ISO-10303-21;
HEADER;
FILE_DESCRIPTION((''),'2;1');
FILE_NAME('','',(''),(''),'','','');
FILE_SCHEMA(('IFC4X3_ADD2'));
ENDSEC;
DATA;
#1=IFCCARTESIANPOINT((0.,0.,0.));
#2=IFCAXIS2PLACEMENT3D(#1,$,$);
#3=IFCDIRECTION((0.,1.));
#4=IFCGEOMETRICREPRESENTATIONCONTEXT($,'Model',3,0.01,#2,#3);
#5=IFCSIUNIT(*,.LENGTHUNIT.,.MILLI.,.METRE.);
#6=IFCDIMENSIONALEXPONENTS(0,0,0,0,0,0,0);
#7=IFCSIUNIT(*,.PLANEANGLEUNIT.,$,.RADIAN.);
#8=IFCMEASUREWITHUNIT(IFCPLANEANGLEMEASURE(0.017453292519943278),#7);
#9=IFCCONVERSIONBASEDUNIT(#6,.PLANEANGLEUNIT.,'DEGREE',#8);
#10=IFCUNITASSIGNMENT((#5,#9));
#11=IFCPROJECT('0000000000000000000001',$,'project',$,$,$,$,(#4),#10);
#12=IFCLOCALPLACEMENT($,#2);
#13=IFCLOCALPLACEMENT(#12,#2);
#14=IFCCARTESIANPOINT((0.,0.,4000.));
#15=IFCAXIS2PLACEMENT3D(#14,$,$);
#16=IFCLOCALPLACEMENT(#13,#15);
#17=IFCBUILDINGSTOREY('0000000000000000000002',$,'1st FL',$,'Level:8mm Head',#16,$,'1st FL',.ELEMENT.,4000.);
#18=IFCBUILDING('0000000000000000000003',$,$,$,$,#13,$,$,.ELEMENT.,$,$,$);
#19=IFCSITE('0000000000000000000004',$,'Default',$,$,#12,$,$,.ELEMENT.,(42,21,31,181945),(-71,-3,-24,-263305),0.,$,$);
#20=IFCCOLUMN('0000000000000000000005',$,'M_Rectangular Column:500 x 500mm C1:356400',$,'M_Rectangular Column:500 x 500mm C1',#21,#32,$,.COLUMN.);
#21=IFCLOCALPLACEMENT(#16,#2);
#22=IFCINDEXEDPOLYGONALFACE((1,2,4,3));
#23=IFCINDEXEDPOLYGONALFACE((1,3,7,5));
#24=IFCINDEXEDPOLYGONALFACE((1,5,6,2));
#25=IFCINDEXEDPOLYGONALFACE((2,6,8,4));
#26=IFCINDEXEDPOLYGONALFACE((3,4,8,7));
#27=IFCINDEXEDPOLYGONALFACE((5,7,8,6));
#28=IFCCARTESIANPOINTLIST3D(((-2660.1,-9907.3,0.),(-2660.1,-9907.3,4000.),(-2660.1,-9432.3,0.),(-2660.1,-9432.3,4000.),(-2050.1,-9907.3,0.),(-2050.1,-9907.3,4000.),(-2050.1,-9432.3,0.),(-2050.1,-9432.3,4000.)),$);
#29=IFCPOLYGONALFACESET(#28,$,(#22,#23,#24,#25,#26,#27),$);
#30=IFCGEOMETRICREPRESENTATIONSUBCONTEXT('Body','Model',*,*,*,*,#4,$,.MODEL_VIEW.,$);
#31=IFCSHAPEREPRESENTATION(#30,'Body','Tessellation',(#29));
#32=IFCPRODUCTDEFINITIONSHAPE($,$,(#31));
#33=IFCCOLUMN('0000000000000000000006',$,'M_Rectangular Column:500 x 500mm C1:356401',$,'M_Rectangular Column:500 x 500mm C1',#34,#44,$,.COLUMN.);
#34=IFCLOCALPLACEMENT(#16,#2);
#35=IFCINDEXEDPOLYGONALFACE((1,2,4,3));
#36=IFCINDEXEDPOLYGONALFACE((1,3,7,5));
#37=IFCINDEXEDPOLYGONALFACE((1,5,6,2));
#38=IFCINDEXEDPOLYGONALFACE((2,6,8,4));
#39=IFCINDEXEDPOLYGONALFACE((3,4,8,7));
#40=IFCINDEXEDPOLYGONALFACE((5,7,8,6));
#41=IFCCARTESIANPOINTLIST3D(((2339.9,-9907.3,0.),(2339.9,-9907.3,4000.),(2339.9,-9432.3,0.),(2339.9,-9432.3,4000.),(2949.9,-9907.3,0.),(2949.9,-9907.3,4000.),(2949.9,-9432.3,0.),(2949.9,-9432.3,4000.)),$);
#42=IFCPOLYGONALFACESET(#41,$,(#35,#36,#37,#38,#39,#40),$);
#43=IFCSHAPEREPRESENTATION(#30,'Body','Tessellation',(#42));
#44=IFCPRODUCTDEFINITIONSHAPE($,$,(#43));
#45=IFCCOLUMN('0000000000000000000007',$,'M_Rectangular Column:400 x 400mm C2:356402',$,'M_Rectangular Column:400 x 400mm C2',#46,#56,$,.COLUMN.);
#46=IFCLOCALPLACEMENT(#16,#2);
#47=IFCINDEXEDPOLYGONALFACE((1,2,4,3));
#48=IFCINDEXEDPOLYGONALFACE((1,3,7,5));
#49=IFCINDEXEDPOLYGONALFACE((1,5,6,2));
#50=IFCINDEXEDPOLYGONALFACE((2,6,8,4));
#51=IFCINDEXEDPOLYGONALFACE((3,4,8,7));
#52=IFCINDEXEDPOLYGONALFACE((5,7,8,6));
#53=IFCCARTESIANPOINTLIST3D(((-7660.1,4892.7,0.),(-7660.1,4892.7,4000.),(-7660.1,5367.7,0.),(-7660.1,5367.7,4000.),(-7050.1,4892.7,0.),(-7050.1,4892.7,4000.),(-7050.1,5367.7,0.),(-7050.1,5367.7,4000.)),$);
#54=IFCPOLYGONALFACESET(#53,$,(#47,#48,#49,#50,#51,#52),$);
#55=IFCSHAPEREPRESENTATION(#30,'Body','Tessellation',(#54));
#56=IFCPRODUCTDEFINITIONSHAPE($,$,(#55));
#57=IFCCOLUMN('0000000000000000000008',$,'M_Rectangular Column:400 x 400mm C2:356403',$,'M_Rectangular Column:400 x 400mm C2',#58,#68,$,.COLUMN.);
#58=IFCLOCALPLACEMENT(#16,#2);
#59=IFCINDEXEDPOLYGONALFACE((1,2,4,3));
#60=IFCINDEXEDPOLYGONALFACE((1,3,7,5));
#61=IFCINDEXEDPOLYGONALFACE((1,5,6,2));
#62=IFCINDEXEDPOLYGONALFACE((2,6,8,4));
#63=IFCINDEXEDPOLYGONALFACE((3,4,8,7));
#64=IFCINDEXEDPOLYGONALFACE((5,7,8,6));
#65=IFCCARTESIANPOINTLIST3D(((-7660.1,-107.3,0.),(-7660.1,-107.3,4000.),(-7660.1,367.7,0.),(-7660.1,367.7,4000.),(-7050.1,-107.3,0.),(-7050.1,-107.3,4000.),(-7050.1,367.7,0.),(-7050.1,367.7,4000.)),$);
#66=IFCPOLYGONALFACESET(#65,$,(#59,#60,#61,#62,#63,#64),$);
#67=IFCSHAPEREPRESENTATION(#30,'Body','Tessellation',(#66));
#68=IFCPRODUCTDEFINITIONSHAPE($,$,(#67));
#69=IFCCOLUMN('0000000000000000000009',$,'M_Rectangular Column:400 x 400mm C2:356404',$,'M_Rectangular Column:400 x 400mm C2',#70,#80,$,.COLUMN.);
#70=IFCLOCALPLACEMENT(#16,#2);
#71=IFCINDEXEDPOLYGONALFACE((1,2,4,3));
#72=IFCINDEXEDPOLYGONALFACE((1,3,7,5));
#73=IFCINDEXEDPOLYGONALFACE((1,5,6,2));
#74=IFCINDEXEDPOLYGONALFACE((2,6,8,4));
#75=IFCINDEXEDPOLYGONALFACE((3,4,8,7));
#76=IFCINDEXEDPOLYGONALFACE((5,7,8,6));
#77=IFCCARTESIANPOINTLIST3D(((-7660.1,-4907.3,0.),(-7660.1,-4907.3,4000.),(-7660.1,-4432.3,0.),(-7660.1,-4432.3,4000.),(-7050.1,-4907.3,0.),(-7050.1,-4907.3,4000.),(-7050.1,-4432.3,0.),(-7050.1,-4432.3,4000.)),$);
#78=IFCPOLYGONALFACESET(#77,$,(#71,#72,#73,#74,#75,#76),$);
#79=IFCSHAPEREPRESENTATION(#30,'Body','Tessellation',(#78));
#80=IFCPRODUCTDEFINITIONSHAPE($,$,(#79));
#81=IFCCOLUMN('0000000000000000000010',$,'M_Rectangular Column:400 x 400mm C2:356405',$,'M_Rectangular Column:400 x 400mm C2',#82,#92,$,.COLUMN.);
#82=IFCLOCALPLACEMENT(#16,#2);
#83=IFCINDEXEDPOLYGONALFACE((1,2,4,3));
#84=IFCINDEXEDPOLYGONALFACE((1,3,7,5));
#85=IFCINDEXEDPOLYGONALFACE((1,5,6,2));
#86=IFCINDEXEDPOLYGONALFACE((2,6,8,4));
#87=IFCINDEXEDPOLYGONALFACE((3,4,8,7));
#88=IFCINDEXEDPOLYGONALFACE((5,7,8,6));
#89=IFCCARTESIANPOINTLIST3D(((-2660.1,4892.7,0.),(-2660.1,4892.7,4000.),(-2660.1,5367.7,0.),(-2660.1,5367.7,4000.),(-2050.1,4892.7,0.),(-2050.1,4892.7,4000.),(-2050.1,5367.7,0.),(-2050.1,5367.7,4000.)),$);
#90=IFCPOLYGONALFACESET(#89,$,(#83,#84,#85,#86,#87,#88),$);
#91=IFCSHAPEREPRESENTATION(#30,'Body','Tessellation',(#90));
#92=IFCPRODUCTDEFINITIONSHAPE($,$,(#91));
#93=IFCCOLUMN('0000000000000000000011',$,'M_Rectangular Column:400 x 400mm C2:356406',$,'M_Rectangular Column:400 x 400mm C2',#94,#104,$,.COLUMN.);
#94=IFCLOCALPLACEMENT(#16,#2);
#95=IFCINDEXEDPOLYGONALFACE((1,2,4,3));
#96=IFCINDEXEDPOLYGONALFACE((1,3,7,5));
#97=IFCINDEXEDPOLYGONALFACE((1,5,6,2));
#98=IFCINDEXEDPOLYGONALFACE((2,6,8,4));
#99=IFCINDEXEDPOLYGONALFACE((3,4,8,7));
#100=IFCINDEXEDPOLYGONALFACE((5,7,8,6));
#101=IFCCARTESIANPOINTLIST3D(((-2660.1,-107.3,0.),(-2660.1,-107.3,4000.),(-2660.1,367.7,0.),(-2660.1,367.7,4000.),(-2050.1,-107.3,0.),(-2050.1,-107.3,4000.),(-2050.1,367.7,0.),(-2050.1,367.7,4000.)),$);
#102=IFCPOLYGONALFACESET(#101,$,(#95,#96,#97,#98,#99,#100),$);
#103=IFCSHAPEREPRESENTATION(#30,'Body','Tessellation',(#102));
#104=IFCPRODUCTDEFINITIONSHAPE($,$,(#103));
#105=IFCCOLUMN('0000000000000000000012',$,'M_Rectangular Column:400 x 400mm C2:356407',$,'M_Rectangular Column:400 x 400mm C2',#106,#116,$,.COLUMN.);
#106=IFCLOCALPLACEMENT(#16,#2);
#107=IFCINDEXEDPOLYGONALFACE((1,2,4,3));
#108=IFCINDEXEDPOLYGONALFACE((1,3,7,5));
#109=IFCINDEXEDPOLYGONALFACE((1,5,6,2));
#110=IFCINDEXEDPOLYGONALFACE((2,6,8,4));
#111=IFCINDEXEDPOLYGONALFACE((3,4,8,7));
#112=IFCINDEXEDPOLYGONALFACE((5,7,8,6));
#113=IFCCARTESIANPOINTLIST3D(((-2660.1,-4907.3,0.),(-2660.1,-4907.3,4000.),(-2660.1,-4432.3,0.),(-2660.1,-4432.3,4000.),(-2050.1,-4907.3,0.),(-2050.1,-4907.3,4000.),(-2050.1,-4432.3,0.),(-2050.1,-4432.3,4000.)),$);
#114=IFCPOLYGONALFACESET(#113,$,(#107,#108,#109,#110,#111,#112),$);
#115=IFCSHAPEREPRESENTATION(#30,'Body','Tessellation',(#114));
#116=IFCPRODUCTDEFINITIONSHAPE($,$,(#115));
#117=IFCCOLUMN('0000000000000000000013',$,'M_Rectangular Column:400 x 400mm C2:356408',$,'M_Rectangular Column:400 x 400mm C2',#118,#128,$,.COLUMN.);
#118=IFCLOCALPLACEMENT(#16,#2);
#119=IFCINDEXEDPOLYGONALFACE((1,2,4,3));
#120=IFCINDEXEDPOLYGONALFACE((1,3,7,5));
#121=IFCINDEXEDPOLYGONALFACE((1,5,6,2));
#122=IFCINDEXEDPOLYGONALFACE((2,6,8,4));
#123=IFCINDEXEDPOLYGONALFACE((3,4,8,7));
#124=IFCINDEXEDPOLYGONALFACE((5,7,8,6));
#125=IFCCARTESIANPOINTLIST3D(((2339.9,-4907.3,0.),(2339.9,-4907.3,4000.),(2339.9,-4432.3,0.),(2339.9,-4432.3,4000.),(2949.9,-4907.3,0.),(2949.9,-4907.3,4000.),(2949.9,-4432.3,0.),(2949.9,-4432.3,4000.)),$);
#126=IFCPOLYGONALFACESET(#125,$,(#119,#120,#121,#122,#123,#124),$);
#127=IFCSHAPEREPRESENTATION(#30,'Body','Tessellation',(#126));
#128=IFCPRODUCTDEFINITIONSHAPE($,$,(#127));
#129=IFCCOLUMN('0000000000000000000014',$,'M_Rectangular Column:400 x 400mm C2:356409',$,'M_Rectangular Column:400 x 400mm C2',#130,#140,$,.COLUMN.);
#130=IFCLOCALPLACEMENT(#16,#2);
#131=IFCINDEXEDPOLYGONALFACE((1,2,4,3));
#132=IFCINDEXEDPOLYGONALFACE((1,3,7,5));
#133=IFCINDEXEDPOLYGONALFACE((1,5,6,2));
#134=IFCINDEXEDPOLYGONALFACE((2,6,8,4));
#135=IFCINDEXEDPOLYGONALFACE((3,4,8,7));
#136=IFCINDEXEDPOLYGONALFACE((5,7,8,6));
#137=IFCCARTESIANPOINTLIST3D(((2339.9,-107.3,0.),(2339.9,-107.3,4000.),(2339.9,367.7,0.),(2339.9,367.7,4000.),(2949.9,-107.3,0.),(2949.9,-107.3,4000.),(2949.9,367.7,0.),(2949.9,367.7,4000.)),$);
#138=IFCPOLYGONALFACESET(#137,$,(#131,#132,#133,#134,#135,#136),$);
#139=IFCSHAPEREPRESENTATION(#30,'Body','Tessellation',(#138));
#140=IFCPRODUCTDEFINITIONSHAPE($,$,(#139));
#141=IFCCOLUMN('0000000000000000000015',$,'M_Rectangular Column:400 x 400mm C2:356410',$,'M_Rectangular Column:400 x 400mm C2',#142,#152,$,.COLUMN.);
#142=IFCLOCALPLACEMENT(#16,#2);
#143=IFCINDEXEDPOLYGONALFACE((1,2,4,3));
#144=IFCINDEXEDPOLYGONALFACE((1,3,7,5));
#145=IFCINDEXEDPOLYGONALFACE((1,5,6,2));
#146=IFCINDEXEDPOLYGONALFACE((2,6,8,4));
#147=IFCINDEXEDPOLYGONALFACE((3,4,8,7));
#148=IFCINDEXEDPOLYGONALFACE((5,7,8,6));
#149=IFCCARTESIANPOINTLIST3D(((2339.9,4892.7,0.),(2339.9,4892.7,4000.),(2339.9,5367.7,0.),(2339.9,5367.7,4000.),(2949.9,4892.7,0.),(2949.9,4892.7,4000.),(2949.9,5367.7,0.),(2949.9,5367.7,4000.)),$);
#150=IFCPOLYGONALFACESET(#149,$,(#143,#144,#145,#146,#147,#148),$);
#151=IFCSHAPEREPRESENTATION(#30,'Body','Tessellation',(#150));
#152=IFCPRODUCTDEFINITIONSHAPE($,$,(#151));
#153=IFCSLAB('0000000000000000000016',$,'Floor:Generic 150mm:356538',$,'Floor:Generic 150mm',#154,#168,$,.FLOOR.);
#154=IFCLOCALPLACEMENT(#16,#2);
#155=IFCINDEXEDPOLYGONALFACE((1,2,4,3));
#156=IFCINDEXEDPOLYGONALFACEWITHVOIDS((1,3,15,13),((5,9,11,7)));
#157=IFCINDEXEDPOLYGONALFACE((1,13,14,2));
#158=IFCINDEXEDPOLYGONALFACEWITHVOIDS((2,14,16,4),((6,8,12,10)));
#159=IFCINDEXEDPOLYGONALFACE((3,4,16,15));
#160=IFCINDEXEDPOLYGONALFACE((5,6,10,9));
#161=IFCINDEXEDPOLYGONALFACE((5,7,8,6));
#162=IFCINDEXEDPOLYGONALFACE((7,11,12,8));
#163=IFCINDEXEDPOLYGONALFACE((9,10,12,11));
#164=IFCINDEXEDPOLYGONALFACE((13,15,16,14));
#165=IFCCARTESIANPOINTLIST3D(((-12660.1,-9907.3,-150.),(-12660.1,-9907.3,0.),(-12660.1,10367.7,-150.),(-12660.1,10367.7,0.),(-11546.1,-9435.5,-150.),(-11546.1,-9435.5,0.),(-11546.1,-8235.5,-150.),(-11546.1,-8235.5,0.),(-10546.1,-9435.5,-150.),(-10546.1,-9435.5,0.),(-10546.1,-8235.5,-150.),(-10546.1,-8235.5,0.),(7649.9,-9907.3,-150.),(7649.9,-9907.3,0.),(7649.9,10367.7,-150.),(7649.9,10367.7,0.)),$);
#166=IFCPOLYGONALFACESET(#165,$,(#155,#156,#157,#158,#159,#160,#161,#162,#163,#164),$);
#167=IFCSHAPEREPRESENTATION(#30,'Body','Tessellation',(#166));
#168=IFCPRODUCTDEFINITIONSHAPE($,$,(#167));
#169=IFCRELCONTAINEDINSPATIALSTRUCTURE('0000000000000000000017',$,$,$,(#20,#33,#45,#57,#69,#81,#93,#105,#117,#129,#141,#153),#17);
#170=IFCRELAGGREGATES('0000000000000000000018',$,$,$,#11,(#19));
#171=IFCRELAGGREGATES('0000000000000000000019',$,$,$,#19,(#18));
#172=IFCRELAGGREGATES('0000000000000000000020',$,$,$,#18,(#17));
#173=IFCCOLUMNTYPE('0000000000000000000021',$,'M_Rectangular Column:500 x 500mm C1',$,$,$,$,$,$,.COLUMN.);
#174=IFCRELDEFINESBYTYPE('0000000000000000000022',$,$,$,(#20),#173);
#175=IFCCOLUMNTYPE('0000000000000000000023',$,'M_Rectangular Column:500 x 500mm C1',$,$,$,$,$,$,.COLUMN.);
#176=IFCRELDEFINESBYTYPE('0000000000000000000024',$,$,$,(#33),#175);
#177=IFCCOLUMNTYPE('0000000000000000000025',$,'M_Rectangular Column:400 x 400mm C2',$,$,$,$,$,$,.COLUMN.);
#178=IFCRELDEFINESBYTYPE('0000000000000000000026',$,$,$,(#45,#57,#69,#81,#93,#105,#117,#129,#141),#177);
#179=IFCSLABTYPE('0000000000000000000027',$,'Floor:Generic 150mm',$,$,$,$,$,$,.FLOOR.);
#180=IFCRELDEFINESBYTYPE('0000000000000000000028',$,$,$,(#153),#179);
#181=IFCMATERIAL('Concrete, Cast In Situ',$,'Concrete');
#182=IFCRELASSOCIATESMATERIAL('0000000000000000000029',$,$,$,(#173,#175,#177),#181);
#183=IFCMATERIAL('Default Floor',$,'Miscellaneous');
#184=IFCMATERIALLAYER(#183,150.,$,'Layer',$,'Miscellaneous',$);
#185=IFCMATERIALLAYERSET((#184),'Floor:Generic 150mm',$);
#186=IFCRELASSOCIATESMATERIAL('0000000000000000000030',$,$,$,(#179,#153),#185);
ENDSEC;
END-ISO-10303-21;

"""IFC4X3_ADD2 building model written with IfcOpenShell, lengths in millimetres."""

from ifc_helpers import new_model, entity, si_unit, converted_unit, direction, frame, frame_2d, origin, origin_2d_with_axis, place, context, subcontext, project, spatial, rectangle, extrude, boolean, source, transform, mapped, material, layer, layer_set, layer_usage, material_profile, profile_set, type_object, type_shapes, element, save


model = new_model("IFC4X3_ADD2")

# Units and contexts
model_context = context("Model", 3, precision=0.01, world=origin(), true_north=direction((0.0, 1.0)))
body_context = subcontext(model_context, "Body", "Model", "MODEL_VIEW")
ifc_project = project(units=[si_unit("LENGTHUNIT", "METRE", prefix="MILLI"), converted_unit("PLANEANGLEUNIT", "DEGREE", entity("IfcPlaneAngleMeasure", 0.017453292519943278), si_unit("PLANEANGLEUNIT", "RADIAN"), dimensions=[0, 0, 0, 0, 0, 0, 0])], contexts=[model_context])

# Site, building, storey
site_placement = place(None, origin())
site = spatial("IfcSite", under=ifc_project, at=site_placement, Name="Default", CompositionType="ELEMENT", RefLatitude=(42, 21, 31, 181945), RefLongitude=(-71, -3, -24, -263305), RefElevation=0.0)
building_placement = place(site_placement, origin())
building = spatial("IfcBuilding", under=site, at=building_placement, CompositionType="ELEMENT")
storey_placement = place(building_placement, frame((0.0, 0.0, 4000.0)))
storey = spatial("IfcBuildingStorey", under=building, at=storey_placement, Name="1st FL", ObjectType="Level:8mm Head", LongName="1st FL", CompositionType="ELEMENT", Elevation=4000.0)

# Columns
ifc_material_1 = material(Name="Concrete, Cast In Situ", Category="Concrete")
ifc_material_profile_1 = material_profile(ifc_material_1, rectangle(XDim=610.0, YDim=475.0, at=frame_2d((0.0, 0.0), x_axis=(1.0, 0.0))), Name="500 x 500mm C1")
ifc_profile_set_1 = profile_set([ifc_material_profile_1], Name="500 x 500mm C1")
column_type_1 = type_object("IfcColumnType", Name="M_Rectangular Column:500 x 500mm C1", PredefinedType="COLUMN", material=ifc_profile_set_1)
shared_shape_1 = source(origin(), body_context, "Body", "SweptSolid", [
    extrude(rectangle(XDim=610.0, YDim=475.0, at=frame_2d((0.0, 0.0), x_axis=(1.0, 0.0))), frame((-2355.1, -9669.8, 4000.0), z_axis=(0.0, 0.0, 1.0), x_axis=(-1.0, 0.0, 0.0)), (0.0, 0.0, 1.0), 4000.0),
])
type_shapes(column_type_1, [shared_shape_1])
column_1_placement = place(storey_placement, frame((0.0, 0.0, -4000.0)))
element("IfcColumn", 1, at=column_1_placement, inside=storey, type_object=column_type_1, Name="M_Rectangular Column:500 x 500mm C1:356400", ObjectType="M_Rectangular Column:500 x 500mm C1", PredefinedType="COLUMN", context=body_context, shape_type="MappedRepresentation", body=[
    mapped(shared_shape_1, transform((0.0, 0.0, 0.0), scale=1.0)),
])
column_type_2 = type_object("IfcColumnType", Name="M_Rectangular Column:500 x 500mm C1", PredefinedType="COLUMN", material=ifc_profile_set_1)
shared_shape_2 = source(origin(), body_context, "Body", "SweptSolid", [
    extrude(rectangle(XDim=610.0, YDim=475.0, at=frame_2d((0.0, 0.0), x_axis=(1.0, 0.0))), frame((2644.9, -9669.8, 4000.0), z_axis=(0.0, 0.0, 1.0), x_axis=(-1.0, 0.0, 0.0)), (0.0, 0.0, 1.0), 4000.0),
])
type_shapes(column_type_2, [shared_shape_2])
column_2_placement = place(storey_placement, frame((0.0, 0.0, -4000.0)))
element("IfcColumn", 2, at=column_2_placement, inside=storey, type_object=column_type_2, Name="M_Rectangular Column:500 x 500mm C1:356401", ObjectType="M_Rectangular Column:500 x 500mm C1", PredefinedType="COLUMN", context=body_context, shape_type="MappedRepresentation", body=[
    mapped(shared_shape_2, transform((0.0, 0.0, 0.0), scale=1.0)),
])
ifc_material_profile_2 = material_profile(ifc_material_1, rectangle(XDim=610.0, YDim=475.0, at=origin_2d_with_axis()), Name="400 x 400mm C2")
ifc_profile_set_2 = profile_set([ifc_material_profile_2], Name="400 x 400mm C2")
column_type_3 = type_object("IfcColumnType", Name="M_Rectangular Column:400 x 400mm C2", PredefinedType="COLUMN", material=ifc_profile_set_2)
shared_shape_3 = source(origin(), body_context, "Body", "SweptSolid", [
    extrude(rectangle(XDim=610.0, YDim=475.0, at=origin_2d_with_axis()), frame((0.0, 0.0, 4000.0), z_axis=(0.0, 0.0, 1.0), x_axis=(-1.0, 0.0, 0.0)), (0.0, 0.0, 1.0), 4000.0),
])
type_shapes(column_type_3, [shared_shape_3])
for number, where, name in (
    (3, (-7355.1, 5130.2, -4000.0), "M_Rectangular Column:400 x 400mm C2:356402"),
    (4, (-7355.1, 130.2, -4000.0), "M_Rectangular Column:400 x 400mm C2:356403"),
    (5, (-7355.1, -4669.8, -4000.0), "M_Rectangular Column:400 x 400mm C2:356404"),
    (6, (-2355.1, 5130.2, -4000.0), "M_Rectangular Column:400 x 400mm C2:356405"),
    (7, (-2355.1, 130.2, -4000.0), "M_Rectangular Column:400 x 400mm C2:356406"),
    (8, (-2355.1, -4669.8, -4000.0), "M_Rectangular Column:400 x 400mm C2:356407"),
    (9, (2644.9, -4669.8, -4000.0), "M_Rectangular Column:400 x 400mm C2:356408"),
    (10, (2644.9, 130.2, -4000.0), "M_Rectangular Column:400 x 400mm C2:356409"),
    (11, (2644.9, 5130.2, -4000.0), "M_Rectangular Column:400 x 400mm C2:356410"),
):
    element("IfcColumn", number, at=place(storey_placement, frame(where)), inside=storey, type_object=column_type_3, Name=name, ObjectType="M_Rectangular Column:400 x 400mm C2", PredefinedType="COLUMN", context=body_context, shape_type="MappedRepresentation", body=[
        mapped(shared_shape_3, transform((0.0, 0.0, 0.0), scale=1.0)),
    ])

# Slab, opening
ifc_material_2 = material(Name="Default Floor", Category="Miscellaneous")
ifc_layer = layer(ifc_material_2, 150.0, Name="Layer", Category="Miscellaneous")
ifc_layer_set = layer_set([ifc_layer], Name="Floor:Generic 150mm")
ifc_layer_usage = layer_usage(ifc_layer_set, "AXIS3", "POSITIVE", 0.0)
slab_type = type_object("IfcSlabType", Name="Floor:Generic 150mm", PredefinedType="FLOOR", material=ifc_layer_set)
slab_placement = place(storey_placement, origin())
slab = element("IfcSlab", 12, at=slab_placement, inside=storey, type_object=slab_type, material=ifc_layer_usage, Name="Floor:Generic 150mm:356538", ObjectType="Floor:Generic 150mm", PredefinedType="FLOOR", context=body_context, shape_type="SweptSolid", body=[
    boolean("DIFFERENCE", extrude(rectangle(XDim=20275.0, YDim=20310.0, at=origin_2d_with_axis()), frame((-2505.1, 230.2, 0.0), z_axis=(0.0, 0.0, -1.0), x_axis=(0.0, 1.0, 0.0)), (0.0, 0.0, 1.0), 150.0), extrude(rectangle(XDim=1200.0, YDim=1000.0, at=frame_2d((0.0, 0.0), x_axis=(1.0, 0.0))), frame((-11046.1, -8835.5, 0.0), z_axis=(0.0, 0.0, -1.0), x_axis=(0.0, -1.0, 0.0)), (0.0, 0.0, 1.0), 150.0)),
])
opening_placement = place(slab_placement, origin())
element("IfcOpeningElement", 13, at=opening_placement, cuts=slab, PredefinedType="OPENING", context=body_context, shape_type="SweptSolid", body=[
    extrude(rectangle(XDim=1200.0, YDim=1000.0, at=frame_2d((0.0, 0.0), x_axis=(1.0, 0.0))), frame((-11046.1, -8835.5, -150.0), z_axis=(0.0, 0.0, 1.0), x_axis=(0.0, 1.0, 0.0)), (0.0, 0.0, 1.0), 150.0),
])

save(model, "model.ifc")
